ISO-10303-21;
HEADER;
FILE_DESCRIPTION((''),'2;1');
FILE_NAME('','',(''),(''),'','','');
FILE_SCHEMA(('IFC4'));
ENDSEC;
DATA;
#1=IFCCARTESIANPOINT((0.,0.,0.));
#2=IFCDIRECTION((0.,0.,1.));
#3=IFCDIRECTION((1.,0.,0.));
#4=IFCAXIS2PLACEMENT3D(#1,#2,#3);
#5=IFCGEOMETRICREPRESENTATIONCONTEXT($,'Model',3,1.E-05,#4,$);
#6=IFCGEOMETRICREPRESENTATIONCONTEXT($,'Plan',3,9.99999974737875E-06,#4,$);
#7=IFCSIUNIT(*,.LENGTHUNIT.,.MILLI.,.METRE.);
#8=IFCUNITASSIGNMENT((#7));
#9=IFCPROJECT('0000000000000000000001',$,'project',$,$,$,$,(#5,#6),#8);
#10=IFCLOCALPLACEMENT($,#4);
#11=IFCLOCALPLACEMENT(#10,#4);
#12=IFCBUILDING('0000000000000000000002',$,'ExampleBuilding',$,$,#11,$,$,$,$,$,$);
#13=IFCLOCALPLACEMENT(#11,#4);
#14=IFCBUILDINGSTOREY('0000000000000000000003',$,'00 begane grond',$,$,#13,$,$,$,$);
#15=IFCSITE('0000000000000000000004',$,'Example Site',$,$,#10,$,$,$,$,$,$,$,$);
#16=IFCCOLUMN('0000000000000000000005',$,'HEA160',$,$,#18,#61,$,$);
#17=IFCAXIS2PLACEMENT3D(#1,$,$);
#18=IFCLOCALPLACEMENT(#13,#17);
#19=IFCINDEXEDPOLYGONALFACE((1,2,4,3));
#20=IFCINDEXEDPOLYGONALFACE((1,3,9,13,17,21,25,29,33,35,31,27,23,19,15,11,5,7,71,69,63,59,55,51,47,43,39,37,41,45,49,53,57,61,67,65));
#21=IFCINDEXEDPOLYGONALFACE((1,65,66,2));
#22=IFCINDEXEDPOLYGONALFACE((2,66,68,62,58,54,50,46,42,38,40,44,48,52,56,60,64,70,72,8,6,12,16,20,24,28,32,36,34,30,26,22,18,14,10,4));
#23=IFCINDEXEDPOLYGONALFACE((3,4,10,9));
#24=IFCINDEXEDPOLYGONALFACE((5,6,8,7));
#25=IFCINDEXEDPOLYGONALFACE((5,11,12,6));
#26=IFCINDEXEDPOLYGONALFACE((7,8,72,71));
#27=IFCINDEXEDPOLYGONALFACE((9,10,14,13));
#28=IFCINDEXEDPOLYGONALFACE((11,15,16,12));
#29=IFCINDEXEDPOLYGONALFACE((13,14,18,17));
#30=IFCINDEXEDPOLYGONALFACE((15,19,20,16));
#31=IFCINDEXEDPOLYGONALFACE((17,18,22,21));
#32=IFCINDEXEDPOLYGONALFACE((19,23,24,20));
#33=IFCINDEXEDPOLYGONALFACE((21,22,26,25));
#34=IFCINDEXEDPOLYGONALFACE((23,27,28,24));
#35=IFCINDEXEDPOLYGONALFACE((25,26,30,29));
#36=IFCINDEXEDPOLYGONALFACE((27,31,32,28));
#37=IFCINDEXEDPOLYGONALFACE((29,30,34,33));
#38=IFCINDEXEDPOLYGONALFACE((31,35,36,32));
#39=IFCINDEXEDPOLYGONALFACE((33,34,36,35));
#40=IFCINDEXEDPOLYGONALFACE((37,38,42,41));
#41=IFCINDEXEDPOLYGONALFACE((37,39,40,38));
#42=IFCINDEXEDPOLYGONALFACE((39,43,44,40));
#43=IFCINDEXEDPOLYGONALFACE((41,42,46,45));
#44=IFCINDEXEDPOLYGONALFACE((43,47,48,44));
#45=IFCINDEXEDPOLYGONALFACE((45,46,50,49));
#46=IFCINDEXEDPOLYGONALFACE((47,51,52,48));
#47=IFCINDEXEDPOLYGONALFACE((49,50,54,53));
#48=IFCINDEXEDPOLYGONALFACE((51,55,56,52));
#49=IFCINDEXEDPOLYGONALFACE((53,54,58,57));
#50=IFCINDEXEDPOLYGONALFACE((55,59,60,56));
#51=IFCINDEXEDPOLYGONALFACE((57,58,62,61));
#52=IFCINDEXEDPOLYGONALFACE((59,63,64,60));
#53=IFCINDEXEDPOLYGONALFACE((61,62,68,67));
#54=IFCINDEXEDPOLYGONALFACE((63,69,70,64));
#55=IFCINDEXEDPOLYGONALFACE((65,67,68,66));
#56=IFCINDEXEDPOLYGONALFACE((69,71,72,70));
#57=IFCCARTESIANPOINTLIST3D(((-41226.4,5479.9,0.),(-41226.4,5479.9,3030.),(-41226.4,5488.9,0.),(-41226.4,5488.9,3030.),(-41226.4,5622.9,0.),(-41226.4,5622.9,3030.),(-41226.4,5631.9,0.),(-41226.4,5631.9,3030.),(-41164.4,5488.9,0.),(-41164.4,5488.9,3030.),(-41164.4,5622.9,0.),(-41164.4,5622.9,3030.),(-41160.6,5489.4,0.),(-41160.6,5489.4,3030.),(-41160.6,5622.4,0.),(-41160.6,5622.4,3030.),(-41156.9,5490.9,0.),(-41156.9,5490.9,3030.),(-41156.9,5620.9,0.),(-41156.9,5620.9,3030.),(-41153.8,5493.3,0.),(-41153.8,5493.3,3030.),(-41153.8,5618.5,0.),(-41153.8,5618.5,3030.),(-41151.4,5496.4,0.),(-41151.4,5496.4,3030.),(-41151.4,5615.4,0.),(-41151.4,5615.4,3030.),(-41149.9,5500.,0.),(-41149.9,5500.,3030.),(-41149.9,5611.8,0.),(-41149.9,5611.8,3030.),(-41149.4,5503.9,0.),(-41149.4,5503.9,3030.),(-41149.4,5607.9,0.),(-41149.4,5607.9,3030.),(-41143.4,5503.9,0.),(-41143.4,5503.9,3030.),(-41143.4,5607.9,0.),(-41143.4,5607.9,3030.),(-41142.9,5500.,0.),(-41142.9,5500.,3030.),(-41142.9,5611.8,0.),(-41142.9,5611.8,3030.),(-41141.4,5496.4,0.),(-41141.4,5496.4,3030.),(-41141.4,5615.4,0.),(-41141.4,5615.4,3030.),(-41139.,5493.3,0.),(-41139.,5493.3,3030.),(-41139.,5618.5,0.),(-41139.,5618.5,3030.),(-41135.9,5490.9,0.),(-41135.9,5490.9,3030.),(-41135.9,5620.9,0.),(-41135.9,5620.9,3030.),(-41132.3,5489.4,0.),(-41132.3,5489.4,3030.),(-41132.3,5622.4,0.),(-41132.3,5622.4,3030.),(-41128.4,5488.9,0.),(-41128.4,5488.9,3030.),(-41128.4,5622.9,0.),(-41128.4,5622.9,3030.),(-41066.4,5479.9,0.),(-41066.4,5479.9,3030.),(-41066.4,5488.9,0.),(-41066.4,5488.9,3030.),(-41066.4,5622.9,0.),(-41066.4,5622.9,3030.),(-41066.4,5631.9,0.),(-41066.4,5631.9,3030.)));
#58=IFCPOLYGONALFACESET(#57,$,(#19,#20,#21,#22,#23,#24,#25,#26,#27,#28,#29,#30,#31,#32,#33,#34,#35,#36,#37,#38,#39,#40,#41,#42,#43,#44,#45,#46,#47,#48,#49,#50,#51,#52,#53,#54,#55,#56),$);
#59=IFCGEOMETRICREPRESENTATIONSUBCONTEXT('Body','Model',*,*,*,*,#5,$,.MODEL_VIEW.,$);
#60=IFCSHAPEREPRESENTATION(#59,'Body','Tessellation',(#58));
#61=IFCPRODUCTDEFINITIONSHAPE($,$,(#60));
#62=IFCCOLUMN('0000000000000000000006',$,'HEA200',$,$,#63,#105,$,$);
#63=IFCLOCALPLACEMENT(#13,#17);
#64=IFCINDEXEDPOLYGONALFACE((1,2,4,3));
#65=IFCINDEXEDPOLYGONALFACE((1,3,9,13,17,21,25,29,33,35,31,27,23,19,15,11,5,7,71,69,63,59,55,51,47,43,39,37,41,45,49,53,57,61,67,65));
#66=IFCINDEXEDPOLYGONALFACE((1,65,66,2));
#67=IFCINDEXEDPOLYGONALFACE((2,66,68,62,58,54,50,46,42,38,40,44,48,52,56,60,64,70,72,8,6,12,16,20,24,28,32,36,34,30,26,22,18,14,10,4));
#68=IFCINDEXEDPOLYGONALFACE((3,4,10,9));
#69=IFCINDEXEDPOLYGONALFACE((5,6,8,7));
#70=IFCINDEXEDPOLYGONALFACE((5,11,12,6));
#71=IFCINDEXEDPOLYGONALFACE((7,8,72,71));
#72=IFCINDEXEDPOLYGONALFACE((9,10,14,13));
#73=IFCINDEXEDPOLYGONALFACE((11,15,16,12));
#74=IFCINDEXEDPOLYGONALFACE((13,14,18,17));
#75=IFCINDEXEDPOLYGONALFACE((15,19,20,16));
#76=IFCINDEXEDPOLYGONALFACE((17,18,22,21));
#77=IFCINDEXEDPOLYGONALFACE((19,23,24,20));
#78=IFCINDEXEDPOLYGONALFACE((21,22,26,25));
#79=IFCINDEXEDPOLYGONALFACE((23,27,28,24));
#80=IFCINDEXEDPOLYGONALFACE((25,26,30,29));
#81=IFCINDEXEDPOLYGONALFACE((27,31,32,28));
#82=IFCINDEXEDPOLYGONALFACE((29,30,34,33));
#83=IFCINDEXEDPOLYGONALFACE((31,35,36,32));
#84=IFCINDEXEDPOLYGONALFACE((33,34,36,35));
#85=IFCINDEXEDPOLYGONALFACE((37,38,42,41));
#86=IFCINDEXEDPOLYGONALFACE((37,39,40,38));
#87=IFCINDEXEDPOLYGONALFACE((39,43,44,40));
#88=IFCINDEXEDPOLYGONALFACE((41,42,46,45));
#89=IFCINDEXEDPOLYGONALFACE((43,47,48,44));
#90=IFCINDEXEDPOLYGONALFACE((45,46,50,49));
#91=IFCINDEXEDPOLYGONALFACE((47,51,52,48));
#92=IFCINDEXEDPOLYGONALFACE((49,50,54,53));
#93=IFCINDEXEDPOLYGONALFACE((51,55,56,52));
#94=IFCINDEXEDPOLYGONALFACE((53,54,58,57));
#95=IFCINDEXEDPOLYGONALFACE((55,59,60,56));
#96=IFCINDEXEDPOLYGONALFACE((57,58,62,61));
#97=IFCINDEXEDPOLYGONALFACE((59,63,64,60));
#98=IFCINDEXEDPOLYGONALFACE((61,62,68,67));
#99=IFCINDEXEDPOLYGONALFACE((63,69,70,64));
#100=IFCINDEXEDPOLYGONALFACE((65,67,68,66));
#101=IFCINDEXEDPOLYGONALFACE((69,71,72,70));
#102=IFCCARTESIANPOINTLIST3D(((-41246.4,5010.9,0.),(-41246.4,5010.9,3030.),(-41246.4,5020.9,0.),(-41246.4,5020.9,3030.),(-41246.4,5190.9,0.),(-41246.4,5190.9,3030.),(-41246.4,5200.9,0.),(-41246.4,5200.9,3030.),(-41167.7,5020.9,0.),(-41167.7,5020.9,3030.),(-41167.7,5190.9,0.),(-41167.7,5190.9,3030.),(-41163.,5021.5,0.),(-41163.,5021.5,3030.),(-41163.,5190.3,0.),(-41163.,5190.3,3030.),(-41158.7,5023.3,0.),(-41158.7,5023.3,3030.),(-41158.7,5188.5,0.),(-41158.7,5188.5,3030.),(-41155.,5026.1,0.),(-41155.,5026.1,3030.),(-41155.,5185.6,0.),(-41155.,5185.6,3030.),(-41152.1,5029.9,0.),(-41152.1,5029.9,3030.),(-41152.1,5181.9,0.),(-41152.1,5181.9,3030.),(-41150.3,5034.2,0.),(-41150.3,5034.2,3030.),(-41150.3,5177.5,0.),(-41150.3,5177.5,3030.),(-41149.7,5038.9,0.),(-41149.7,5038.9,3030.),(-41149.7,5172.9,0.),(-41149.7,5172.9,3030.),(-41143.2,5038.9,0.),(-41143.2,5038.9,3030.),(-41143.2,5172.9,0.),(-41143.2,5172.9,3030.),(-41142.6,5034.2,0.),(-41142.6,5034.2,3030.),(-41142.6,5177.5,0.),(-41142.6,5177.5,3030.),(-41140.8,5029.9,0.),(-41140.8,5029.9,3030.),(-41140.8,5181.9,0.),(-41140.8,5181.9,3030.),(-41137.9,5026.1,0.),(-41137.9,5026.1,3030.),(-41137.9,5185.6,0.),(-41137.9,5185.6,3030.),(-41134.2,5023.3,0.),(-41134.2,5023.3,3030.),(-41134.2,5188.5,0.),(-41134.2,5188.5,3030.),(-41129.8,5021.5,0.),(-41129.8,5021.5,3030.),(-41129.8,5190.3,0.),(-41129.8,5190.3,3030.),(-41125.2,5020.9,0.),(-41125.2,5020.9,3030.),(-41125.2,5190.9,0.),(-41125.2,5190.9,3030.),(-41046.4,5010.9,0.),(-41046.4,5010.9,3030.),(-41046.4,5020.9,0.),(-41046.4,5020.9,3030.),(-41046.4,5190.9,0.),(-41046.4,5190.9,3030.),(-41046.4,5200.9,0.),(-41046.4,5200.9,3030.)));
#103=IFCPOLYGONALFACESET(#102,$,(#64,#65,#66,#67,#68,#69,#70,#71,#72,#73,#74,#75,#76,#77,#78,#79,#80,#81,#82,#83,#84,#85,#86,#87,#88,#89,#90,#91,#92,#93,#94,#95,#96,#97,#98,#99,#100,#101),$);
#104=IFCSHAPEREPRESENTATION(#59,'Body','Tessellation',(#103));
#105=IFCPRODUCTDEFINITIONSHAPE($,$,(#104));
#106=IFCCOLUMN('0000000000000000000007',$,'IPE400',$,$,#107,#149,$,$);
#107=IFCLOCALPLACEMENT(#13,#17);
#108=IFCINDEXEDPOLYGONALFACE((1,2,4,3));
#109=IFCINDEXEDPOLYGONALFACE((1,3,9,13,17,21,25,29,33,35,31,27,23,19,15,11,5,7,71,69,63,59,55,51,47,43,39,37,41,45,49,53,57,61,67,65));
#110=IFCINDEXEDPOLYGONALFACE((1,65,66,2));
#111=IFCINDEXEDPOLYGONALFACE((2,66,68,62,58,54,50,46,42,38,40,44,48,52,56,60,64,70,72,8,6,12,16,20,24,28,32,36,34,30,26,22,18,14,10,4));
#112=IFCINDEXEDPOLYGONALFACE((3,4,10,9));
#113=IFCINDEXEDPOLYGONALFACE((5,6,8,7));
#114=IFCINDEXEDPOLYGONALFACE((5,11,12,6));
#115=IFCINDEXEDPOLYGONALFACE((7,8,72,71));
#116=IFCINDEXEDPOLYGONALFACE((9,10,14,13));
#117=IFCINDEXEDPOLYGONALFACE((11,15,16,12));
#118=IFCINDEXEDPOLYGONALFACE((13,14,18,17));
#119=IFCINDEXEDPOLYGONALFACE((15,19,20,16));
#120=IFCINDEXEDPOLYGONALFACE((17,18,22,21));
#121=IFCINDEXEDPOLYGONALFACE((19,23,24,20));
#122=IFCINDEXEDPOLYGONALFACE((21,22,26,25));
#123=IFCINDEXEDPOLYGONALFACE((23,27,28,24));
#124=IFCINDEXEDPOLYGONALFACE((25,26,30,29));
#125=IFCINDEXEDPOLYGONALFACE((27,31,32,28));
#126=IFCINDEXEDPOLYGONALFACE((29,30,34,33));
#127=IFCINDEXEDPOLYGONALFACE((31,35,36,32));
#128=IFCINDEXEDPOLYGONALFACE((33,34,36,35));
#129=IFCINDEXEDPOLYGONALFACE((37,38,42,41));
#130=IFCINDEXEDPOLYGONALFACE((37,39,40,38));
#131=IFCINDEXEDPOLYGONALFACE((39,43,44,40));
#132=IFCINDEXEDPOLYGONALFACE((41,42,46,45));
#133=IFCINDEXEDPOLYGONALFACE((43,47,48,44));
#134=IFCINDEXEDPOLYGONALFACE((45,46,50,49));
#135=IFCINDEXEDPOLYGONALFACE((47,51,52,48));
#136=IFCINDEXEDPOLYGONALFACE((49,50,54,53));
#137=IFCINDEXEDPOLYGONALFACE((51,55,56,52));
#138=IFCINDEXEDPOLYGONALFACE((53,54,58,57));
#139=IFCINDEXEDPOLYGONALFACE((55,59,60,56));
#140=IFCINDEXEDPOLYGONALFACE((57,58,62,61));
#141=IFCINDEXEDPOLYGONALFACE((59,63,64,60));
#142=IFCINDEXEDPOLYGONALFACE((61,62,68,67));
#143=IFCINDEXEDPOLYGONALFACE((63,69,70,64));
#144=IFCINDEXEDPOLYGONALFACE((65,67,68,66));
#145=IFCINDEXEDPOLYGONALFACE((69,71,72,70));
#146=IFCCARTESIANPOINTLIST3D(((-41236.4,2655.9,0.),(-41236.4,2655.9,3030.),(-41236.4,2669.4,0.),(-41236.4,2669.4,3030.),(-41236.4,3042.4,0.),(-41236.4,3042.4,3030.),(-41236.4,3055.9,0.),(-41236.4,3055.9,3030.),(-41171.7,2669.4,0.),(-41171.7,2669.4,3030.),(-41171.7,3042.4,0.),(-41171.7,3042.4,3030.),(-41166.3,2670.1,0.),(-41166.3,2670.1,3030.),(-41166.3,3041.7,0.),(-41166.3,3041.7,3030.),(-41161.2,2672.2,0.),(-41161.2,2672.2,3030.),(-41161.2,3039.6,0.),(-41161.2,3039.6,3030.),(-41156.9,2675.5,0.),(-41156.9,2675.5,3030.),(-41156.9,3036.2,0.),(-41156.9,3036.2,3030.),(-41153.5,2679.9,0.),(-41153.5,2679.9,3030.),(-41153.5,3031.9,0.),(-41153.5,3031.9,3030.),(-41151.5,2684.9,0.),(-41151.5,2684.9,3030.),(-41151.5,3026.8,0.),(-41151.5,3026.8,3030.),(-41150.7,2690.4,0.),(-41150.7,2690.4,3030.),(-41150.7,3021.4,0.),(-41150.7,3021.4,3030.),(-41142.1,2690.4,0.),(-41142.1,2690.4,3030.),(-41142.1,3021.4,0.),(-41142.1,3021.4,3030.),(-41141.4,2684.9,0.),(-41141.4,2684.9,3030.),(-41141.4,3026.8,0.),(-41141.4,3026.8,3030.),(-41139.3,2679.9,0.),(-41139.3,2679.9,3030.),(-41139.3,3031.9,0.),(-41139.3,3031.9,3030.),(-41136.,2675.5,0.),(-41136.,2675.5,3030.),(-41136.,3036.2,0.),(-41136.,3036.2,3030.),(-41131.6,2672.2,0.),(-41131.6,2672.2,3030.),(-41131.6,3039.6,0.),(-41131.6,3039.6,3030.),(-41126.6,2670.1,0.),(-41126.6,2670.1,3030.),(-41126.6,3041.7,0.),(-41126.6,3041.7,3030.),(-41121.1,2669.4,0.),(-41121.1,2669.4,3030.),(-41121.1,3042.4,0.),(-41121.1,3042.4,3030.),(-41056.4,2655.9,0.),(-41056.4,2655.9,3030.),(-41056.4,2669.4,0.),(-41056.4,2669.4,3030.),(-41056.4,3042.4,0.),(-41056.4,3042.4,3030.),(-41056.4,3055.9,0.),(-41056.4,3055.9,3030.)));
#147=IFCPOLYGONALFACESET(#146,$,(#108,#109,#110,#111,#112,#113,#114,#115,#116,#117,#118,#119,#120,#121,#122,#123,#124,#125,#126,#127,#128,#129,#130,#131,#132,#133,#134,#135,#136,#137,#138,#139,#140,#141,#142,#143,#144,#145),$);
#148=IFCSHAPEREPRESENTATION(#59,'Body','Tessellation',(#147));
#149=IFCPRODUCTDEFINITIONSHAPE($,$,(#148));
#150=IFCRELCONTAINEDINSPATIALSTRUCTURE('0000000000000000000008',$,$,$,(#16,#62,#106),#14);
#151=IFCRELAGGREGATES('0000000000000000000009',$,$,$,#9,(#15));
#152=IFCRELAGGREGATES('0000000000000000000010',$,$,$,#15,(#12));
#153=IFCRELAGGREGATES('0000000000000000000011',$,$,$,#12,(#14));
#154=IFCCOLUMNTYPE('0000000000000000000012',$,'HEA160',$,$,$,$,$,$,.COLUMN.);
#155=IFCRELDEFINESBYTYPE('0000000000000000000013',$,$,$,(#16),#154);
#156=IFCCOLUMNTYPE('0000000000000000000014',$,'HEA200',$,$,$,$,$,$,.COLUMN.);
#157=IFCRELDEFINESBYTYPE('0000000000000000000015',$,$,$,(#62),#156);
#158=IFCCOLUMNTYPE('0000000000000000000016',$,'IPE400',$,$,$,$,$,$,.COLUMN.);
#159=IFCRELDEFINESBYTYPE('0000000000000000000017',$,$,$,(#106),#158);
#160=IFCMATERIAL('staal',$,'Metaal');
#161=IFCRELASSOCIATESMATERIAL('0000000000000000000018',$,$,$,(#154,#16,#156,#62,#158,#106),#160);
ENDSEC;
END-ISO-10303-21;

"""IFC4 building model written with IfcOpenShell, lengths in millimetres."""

from ifc_helpers import new_model, si_unit, frame, origin_with_axes, place, context, subcontext, project, spatial, i_section, extrude, material, material_profile, profile_set, profile_usage, type_object, element, save


model = new_model("IFC4")

# Units and contexts
model_context = context("Model", 3, precision=1e-05, world=origin_with_axes())
plan_context = context("Plan", 3, precision=9.99999974737875e-06, world=origin_with_axes())
body_context = subcontext(model_context, "Body", "Model", "MODEL_VIEW")
ifc_project = project(units=[si_unit("LENGTHUNIT", "METRE", prefix="MILLI")], contexts=[model_context, plan_context])

# Site, building, storey
site_placement = place(None, frame((0.0, 0.0, 0.0), z_axis=(0.0, 0.0, 1.0), x_axis=(1.0, 0.0, 0.0)))
site = spatial("IfcSite", under=ifc_project, at=site_placement, Name="Example Site")
building_placement = place(site_placement, frame((0.0, 0.0, 0.0), z_axis=(0.0, 0.0, 1.0), x_axis=(1.0, 0.0, 0.0)))
building = spatial("IfcBuilding", under=site, at=building_placement, Name="ExampleBuilding")
storey_placement = place(building_placement, frame((0.0, 0.0, 0.0), z_axis=(0.0, 0.0, 1.0), x_axis=(1.0, 0.0, 0.0)))
storey = spatial("IfcBuildingStorey", under=building, at=storey_placement, Name="00 begane grond")

# Columns
ifc_material_1 = material(Name="staal", Category="Metaal")
ifc_material_profile_1 = material_profile(ifc_material_1, i_section(OverallWidth=160.0, OverallDepth=152.0, WebThickness=6.0, FlangeThickness=9.0, FilletRadius=15.0))
ifc_profile_set_1 = profile_set([ifc_material_profile_1], Name="staal")
ifc_profile_usage_1 = profile_usage(ifc_profile_set_1, cardinal=5)
column_type_1 = type_object("IfcColumnType", Name="HEA160", PredefinedType="COLUMN", material=ifc_profile_set_1)
column_1_placement = place(storey_placement, frame((-41146.4, 5555.9, 0.0), z_axis=(0.0, 0.0, 1.0), x_axis=(1.0, 0.0, 0.0)))
element("IfcColumn", 1, at=column_1_placement, inside=storey, type_object=column_type_1, material=ifc_profile_usage_1, Name="HEA160", context=body_context, shape_type="SweptSolid", body=[
    extrude(i_section(OverallWidth=160.0, OverallDepth=152.0, WebThickness=6.0, FlangeThickness=9.0, FilletRadius=15.0), origin_with_axes(), (0.0, 0.0, 1.0), 3030.0),
])
ifc_material_profile_2 = material_profile(ifc_material_1, i_section(OverallWidth=200.0, OverallDepth=190.0, WebThickness=6.5, FlangeThickness=10.0, FilletRadius=18.0))
ifc_profile_set_2 = profile_set([ifc_material_profile_2], Name="staal")
ifc_profile_usage_2 = profile_usage(ifc_profile_set_2, cardinal=5)
column_type_2 = type_object("IfcColumnType", Name="HEA200", PredefinedType="COLUMN", material=ifc_profile_set_2)
column_2_placement = place(storey_placement, frame((-41146.4, 5105.9, 0.0), z_axis=(0.0, 0.0, 1.0), x_axis=(1.0, 0.0, 0.0)))
element("IfcColumn", 2, at=column_2_placement, inside=storey, type_object=column_type_2, material=ifc_profile_usage_2, Name="HEA200", context=body_context, shape_type="SweptSolid", body=[
    extrude(i_section(OverallWidth=200.0, OverallDepth=190.0, WebThickness=6.5, FlangeThickness=10.0, FilletRadius=18.0), origin_with_axes(), (0.0, 0.0, 1.0), 3030.0),
])
ifc_material_profile_3 = material_profile(ifc_material_1, i_section(OverallWidth=180.0, OverallDepth=400.0, WebThickness=8.6, FlangeThickness=13.5, FilletRadius=21.0))
ifc_profile_set_3 = profile_set([ifc_material_profile_3], Name="staal")
ifc_profile_usage_3 = profile_usage(ifc_profile_set_3)
column_type_3 = type_object("IfcColumnType", Name="IPE400", PredefinedType="COLUMN", material=ifc_profile_set_3)
column_3_placement = place(storey_placement, frame((-41146.4, 2855.9, 0.0), z_axis=(0.0, 0.0, 1.0), x_axis=(1.0, 0.0, 0.0)))
element("IfcColumn", 3, at=column_3_placement, inside=storey, type_object=column_type_3, material=ifc_profile_usage_3, Name="IPE400", context=body_context, shape_type="SweptSolid", body=[
    extrude(i_section(OverallWidth=180.0, OverallDepth=400.0, WebThickness=8.6, FlangeThickness=13.5, FilletRadius=21.0), origin_with_axes(), (0.0, 0.0, 1.0), 3030.0),
])

save(model, "model.ifc")
